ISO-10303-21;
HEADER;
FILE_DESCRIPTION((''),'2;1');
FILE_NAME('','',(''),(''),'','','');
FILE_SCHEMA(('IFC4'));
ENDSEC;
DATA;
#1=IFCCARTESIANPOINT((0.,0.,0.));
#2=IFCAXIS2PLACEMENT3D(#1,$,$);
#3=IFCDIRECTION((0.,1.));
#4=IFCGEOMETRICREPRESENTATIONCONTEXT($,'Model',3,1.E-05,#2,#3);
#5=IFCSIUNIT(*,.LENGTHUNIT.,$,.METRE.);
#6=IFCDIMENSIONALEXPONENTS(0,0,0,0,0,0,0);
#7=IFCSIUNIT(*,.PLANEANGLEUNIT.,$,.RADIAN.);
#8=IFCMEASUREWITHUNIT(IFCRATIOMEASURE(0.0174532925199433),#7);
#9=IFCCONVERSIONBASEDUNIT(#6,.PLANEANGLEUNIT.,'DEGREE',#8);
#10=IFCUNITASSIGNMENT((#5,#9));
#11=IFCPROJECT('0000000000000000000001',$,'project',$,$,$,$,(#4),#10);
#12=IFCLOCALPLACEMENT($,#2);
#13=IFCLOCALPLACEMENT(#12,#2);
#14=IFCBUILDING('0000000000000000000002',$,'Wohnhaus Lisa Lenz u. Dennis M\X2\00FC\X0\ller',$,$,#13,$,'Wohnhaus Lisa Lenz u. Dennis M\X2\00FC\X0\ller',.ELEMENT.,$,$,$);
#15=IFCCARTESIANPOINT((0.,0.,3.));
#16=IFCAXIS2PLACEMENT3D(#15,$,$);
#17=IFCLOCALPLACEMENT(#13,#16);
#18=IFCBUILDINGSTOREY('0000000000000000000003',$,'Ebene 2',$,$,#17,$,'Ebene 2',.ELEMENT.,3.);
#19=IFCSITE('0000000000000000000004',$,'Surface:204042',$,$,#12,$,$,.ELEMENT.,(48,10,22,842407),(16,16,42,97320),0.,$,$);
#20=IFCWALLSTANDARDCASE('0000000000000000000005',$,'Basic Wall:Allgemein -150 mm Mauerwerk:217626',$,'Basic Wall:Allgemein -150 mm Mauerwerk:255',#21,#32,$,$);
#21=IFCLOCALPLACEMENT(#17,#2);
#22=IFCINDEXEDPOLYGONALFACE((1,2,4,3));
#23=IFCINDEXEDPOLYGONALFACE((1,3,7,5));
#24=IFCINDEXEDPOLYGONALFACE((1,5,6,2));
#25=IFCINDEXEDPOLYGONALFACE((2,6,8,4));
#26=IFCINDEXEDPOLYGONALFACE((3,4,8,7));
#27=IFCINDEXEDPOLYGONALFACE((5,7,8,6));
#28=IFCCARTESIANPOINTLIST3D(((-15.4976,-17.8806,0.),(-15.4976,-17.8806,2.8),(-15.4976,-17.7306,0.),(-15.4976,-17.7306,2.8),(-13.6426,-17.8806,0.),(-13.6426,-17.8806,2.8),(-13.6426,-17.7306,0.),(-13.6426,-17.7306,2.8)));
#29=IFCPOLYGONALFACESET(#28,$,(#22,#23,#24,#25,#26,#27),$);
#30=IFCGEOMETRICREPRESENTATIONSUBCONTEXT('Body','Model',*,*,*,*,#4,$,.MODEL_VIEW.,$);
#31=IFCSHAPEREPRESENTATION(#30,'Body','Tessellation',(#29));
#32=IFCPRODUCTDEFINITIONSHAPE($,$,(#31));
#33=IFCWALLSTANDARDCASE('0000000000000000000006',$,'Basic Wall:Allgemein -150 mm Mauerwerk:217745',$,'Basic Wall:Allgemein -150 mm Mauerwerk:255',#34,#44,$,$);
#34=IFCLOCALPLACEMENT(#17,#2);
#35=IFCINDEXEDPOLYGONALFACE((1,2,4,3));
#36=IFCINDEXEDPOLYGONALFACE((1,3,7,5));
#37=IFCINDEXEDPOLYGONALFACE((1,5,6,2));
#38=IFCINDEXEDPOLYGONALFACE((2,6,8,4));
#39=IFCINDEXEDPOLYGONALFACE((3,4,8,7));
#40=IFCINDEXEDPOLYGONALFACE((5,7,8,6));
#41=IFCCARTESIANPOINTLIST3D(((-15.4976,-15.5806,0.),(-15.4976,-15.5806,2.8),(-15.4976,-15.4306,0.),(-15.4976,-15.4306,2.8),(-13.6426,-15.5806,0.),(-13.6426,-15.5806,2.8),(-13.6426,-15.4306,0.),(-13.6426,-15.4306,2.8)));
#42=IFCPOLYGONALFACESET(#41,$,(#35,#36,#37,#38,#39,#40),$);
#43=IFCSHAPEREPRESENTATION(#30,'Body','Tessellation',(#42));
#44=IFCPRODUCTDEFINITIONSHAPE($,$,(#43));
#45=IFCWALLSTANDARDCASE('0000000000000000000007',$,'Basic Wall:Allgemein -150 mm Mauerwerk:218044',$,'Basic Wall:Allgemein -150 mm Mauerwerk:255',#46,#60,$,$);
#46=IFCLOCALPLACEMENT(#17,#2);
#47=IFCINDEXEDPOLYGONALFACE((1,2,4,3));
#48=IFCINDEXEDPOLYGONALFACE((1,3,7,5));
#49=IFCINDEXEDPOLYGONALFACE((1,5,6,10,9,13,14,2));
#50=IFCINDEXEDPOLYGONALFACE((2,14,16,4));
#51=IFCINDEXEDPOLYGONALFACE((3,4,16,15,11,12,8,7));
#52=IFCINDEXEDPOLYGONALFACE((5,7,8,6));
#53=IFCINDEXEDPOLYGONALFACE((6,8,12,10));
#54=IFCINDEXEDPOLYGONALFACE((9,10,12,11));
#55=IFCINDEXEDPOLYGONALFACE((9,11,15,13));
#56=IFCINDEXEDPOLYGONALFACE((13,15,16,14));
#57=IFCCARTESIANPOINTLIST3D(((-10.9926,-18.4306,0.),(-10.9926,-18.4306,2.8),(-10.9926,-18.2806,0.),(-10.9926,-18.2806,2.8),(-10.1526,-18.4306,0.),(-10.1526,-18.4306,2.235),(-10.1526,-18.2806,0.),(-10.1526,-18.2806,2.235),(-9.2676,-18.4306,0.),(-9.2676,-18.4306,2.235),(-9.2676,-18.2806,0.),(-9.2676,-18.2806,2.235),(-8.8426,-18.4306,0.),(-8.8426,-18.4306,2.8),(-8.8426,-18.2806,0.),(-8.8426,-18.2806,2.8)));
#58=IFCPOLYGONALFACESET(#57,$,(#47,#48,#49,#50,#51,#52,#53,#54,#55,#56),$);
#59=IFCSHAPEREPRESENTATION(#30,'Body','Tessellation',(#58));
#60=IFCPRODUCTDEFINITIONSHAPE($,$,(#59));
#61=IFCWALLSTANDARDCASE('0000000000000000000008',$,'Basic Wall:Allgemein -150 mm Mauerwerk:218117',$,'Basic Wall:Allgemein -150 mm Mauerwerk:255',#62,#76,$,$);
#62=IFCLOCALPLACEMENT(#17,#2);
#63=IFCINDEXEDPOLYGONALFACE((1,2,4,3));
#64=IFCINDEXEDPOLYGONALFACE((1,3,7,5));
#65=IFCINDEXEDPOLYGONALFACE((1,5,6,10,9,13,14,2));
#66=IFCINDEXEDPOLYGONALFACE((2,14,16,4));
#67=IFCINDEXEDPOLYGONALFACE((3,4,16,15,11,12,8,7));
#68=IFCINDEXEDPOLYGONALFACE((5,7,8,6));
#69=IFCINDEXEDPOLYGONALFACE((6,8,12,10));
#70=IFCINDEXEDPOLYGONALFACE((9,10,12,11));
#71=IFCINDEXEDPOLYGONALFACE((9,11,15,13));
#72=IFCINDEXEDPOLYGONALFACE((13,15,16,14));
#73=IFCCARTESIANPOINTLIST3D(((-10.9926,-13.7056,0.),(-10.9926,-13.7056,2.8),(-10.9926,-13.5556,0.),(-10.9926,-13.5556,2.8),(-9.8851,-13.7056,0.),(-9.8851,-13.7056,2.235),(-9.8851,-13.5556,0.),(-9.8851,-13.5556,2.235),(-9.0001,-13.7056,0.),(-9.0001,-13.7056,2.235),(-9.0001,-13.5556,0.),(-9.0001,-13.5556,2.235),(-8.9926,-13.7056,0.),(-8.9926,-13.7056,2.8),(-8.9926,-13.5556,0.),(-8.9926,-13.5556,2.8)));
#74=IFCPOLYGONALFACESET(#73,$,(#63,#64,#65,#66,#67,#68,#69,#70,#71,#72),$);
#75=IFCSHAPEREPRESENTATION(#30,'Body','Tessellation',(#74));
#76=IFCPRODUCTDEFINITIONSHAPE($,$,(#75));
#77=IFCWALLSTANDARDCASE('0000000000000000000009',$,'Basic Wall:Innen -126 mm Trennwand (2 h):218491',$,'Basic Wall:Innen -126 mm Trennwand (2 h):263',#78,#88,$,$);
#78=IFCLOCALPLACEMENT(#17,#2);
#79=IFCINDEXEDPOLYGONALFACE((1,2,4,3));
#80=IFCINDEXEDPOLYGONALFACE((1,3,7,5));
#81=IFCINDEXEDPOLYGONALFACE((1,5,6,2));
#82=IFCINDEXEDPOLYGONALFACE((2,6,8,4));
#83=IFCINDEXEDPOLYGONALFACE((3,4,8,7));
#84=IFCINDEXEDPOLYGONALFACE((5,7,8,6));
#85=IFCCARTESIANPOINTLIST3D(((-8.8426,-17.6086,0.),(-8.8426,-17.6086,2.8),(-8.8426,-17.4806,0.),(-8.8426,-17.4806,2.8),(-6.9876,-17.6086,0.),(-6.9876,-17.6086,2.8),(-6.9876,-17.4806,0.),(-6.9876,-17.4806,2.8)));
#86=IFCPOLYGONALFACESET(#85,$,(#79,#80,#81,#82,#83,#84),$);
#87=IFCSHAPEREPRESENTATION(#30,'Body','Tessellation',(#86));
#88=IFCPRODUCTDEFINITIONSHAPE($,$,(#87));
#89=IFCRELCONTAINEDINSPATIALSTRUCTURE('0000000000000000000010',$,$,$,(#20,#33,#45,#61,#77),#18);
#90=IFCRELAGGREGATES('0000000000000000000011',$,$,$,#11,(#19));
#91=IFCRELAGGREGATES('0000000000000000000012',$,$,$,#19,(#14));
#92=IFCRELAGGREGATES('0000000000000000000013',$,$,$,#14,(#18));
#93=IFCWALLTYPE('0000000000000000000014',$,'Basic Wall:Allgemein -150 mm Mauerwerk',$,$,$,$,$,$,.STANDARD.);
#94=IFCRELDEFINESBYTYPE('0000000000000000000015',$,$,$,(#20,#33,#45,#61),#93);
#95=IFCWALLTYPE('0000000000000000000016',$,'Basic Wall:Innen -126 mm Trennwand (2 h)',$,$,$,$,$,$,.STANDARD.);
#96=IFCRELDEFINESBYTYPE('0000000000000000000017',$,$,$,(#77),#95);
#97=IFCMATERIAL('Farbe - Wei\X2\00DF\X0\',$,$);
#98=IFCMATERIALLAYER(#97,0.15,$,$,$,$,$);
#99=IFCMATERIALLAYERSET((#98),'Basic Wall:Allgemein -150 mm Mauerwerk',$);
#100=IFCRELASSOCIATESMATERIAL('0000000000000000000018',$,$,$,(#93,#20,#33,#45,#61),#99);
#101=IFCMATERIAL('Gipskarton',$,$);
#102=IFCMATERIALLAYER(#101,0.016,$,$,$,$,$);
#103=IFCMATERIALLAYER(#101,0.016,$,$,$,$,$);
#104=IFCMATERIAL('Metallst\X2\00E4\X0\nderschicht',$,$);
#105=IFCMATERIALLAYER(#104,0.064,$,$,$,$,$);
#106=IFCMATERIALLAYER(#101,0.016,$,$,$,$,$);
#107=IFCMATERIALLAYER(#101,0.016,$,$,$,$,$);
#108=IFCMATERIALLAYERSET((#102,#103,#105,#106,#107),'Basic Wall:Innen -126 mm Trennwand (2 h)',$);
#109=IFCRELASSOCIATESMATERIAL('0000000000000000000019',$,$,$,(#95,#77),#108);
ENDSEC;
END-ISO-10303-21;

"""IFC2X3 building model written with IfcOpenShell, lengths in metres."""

from ifc_helpers import new_model, entity, si_unit, converted_unit, direction, frame, frame_2d, origin, place, context, subcontext, project, spatial, polyline, rectangle, extrude, clip, bounded_halfspace, material, layer, layer_set, layer_usage, type_object, element, save


model = new_model("IFC2X3")

# Units and contexts
model_context = context("Model", 3, precision=1e-05, world=origin(), true_north=direction((0.0, 1.0)))
body_context = subcontext(model_context, "Body", "Model", "MODEL_VIEW")
ifc_project = project(units=[si_unit("LENGTHUNIT", "METRE"), converted_unit("PLANEANGLEUNIT", "DEGREE", entity("IfcRatioMeasure", 0.0174532925199433), si_unit("PLANEANGLEUNIT", "RADIAN"), dimensions=[0, 0, 0, 0, 0, 0, 0])], contexts=[model_context])

# Site, building, storey
site_placement = place(None, origin())
site = spatial("IfcSite", under=ifc_project, at=site_placement, Name="Surface:204042", CompositionType="ELEMENT", RefLatitude=(48, 10, 22, 842407), RefLongitude=(16, 16, 42, 97320), RefElevation=0.0)
building_placement = place(site_placement, origin())
building = spatial("IfcBuilding", under=site, at=building_placement, Name="Wohnhaus Lisa Lenz u. Dennis Müller", LongName="Wohnhaus Lisa Lenz u. Dennis Müller", CompositionType="ELEMENT")
storey_placement = place(building_placement, frame((0.0, 0.0, 3.0)))
storey = spatial("IfcBuildingStorey", under=building, at=storey_placement, Name="Ebene 2", LongName="Ebene 2", CompositionType="ELEMENT", Elevation=3.0)

# Shared definitions
ifc_material_1 = material(Name="Farbe - Weiß")
ifc_layer_1 = layer(ifc_material_1, 0.15)
ifc_layer_set_1 = layer_set([ifc_layer_1], Name="Basic Wall:Allgemein -150 mm Mauerwerk")
wall_type_1 = type_object("IfcWallType", Name="Basic Wall:Allgemein -150 mm Mauerwerk", PredefinedType="STANDARD", material=ifc_layer_set_1)

# Walls
ifc_layer_usage_1 = layer_usage(ifc_layer_set_1, "AXIS2", "NEGATIVE", 0.075)
wall_1_placement = place(storey_placement, frame((-13.6426, -17.8056, 0.0), z_axis=(0.0, 0.0, 1.0), x_axis=(-1.0, 0.0, 0.0)))
element("IfcWallStandardCase", 1, at=wall_1_placement, inside=storey, type_object=wall_type_1, material=ifc_layer_usage_1, Name="Basic Wall:Allgemein -150 mm Mauerwerk:217626", ObjectType="Basic Wall:Allgemein -150 mm Mauerwerk:255", context=body_context, shape_type="Clipping", body=[
    clip(extrude(rectangle(XDim=1.855, YDim=0.15, at=frame_2d((0.9275, 0.0), x_axis=(-1.0, 0.0))), origin(), (0.0, 0.0, 1.0), 2.8), bounded_halfspace(frame((0.0, -0.075, 2.8), z_axis=(0.0, 0.0, -1.0), x_axis=(0.0, 1.0, 0.0)), True, frame((0.0, -0.075, 2.8)), polyline([(0.0, 0.0), (1.855, 0.0), (1.855, 0.15), (0.0, 0.15), (0.0, 0.0)]))),
])
ifc_layer_usage_2 = layer_usage(ifc_layer_set_1, "AXIS2", "NEGATIVE", 0.075)
wall_2_placement = place(storey_placement, frame((-13.6426, -15.5056, 0.0), z_axis=(0.0, 0.0, 1.0), x_axis=(-1.0, 0.0, 0.0)))
element("IfcWallStandardCase", 2, at=wall_2_placement, inside=storey, type_object=wall_type_1, material=ifc_layer_usage_2, Name="Basic Wall:Allgemein -150 mm Mauerwerk:217745", ObjectType="Basic Wall:Allgemein -150 mm Mauerwerk:255", context=body_context, shape_type="Clipping", body=[
    clip(extrude(rectangle(XDim=1.855, YDim=0.15, at=frame_2d((0.9275, 0.0), x_axis=(-1.0, 0.0))), origin(), (0.0, 0.0, 1.0), 2.8), bounded_halfspace(frame((0.0, -0.075, 2.8), z_axis=(0.0, 0.0, -1.0), x_axis=(0.0, 1.0, 0.0)), True, frame((0.0, -0.075, 2.8)), polyline([(0.0, 0.0), (1.855, 0.0), (1.855, 0.15), (0.0, 0.15), (0.0, 0.0)]))),
])

# Walls, openings
ifc_layer_usage_3 = layer_usage(ifc_layer_set_1, "AXIS2", "POSITIVE", -0.075)
wall_3_placement = place(storey_placement, frame((-10.9926, -18.3556, 0.0)))
wall_3 = element("IfcWallStandardCase", 3, at=wall_3_placement, inside=storey, type_object=wall_type_1, material=ifc_layer_usage_3, Name="Basic Wall:Allgemein -150 mm Mauerwerk:218044", ObjectType="Basic Wall:Allgemein -150 mm Mauerwerk:255", context=body_context, shape_type="Clipping", body=[
    clip(extrude(rectangle(XDim=2.15, YDim=0.15, at=frame_2d((1.075, 0.0), x_axis=(-1.0, 0.0))), origin(), (0.0, 0.0, 1.0), 2.8), bounded_halfspace(frame((0.0, -0.075, 2.8), z_axis=(0.0, 0.0, -1.0), x_axis=(0.0, -1.0, 0.0)), True, frame((0.0, -0.075, 2.8)), polyline([(0.0, 0.0), (2.15, 0.0), (2.15, 0.15), (2.0, 0.15), (0.0, 0.15), (0.0, 0.0)]))),
])
opening_1_placement = place(wall_3_placement, frame((1.725, 0.075, 0.0)))
element("IfcOpeningElement", 4, at=opening_1_placement, cuts=wall_3, ObjectType="Opening", context=body_context, shape_type="SweptSolid", body=[
    extrude(rectangle(XDim=2.235, YDim=0.885, at=frame_2d((1.1175, 0.4425), x_axis=(1.0, 0.0))), frame((0.0, 0.0, 0.0), z_axis=(0.0, -1.0, 0.0), x_axis=(0.0, 0.0, 1.0)), (0.0, 0.0, 1.0), 0.15),
])
ifc_layer_usage_4 = layer_usage(ifc_layer_set_1, "AXIS2", "NEGATIVE", 0.075)
wall_4_placement = place(storey_placement, frame((-8.9926, -13.6306, 0.0), z_axis=(0.0, 0.0, 1.0), x_axis=(-1.0, 0.0, 0.0)))
wall_4 = element("IfcWallStandardCase", 5, at=wall_4_placement, inside=storey, type_object=wall_type_1, material=ifc_layer_usage_4, Name="Basic Wall:Allgemein -150 mm Mauerwerk:218117", ObjectType="Basic Wall:Allgemein -150 mm Mauerwerk:255", context=body_context, shape_type="Clipping", body=[
    clip(extrude(rectangle(XDim=2.0, YDim=0.15, at=frame_2d((1.0, 0.0), x_axis=(-1.0, 0.0))), origin(), (0.0, 0.0, 1.0), 2.8), bounded_halfspace(frame((0.0, -0.075, 2.8), z_axis=(0.0, 0.0, -1.0), x_axis=(0.0, 1.0, 0.0)), True, frame((0.0, -0.075, 2.8)), polyline([(0.0, 0.0), (2.0, 0.0), (2.0, 0.15), (0.0, 0.15), (0.0, 0.0)]))),
])
opening_2_placement = place(wall_4_placement, frame((0.8925, 0.075, 0.0)))
element("IfcOpeningElement", 6, at=opening_2_placement, cuts=wall_4, ObjectType="Opening", context=body_context, shape_type="SweptSolid", body=[
    extrude(rectangle(XDim=2.235, YDim=0.885, at=frame_2d((1.1175, 0.4425), x_axis=(1.0, 0.0))), frame((0.0, 0.0, 0.0), z_axis=(0.0, -1.0, 0.0), x_axis=(0.0, 0.0, 1.0)), (0.0, 0.0, 1.0), 0.15),
])

# Wall
ifc_material_2 = material(Name="Gipskarton")
ifc_layer_2 = layer(ifc_material_2, 0.016)
ifc_layer_3 = layer(ifc_material_2, 0.016)
ifc_material_3 = material(Name="Metallständerschicht")
ifc_layer_4 = layer(ifc_material_3, 0.064)
ifc_layer_5 = layer(ifc_material_2, 0.016)
ifc_layer_6 = layer(ifc_material_2, 0.016)
ifc_layer_set_2 = layer_set([ifc_layer_2, ifc_layer_3, ifc_layer_4, ifc_layer_5, ifc_layer_6], Name="Basic Wall:Innen -126 mm Trennwand (2 h)")
ifc_layer_usage_5 = layer_usage(ifc_layer_set_2, "AXIS2", "NEGATIVE", 0.064)
wall_type_2 = type_object("IfcWallType", Name="Basic Wall:Innen -126 mm Trennwand (2 h)", PredefinedType="STANDARD", material=ifc_layer_set_2)
wall_5_placement = place(storey_placement, frame((-8.8426, -17.5446, 0.0)))
element("IfcWallStandardCase", 7, at=wall_5_placement, inside=storey, type_object=wall_type_2, material=ifc_layer_usage_5, Name="Basic Wall:Innen -126 mm Trennwand (2 h):218491", ObjectType="Basic Wall:Innen -126 mm Trennwand (2 h):263", context=body_context, shape_type="Clipping", body=[
    clip(extrude(rectangle(XDim=1.855, YDim=0.128, at=frame_2d((0.9275, 0.0), x_axis=(-1.0, 0.0))), origin(), (0.0, 0.0, 1.0), 2.8), bounded_halfspace(frame((0.0, -0.064, 2.8), z_axis=(0.0, 0.0, -1.0), x_axis=(0.0, -1.0, 0.0)), True, frame((0.0, -0.064, 2.8)), polyline([(0.0, 0.0), (1.855, 0.0), (1.855, 0.128), (0.0, 0.128), (0.0, 0.0)]))),
])

save(model, "model.ifc")
